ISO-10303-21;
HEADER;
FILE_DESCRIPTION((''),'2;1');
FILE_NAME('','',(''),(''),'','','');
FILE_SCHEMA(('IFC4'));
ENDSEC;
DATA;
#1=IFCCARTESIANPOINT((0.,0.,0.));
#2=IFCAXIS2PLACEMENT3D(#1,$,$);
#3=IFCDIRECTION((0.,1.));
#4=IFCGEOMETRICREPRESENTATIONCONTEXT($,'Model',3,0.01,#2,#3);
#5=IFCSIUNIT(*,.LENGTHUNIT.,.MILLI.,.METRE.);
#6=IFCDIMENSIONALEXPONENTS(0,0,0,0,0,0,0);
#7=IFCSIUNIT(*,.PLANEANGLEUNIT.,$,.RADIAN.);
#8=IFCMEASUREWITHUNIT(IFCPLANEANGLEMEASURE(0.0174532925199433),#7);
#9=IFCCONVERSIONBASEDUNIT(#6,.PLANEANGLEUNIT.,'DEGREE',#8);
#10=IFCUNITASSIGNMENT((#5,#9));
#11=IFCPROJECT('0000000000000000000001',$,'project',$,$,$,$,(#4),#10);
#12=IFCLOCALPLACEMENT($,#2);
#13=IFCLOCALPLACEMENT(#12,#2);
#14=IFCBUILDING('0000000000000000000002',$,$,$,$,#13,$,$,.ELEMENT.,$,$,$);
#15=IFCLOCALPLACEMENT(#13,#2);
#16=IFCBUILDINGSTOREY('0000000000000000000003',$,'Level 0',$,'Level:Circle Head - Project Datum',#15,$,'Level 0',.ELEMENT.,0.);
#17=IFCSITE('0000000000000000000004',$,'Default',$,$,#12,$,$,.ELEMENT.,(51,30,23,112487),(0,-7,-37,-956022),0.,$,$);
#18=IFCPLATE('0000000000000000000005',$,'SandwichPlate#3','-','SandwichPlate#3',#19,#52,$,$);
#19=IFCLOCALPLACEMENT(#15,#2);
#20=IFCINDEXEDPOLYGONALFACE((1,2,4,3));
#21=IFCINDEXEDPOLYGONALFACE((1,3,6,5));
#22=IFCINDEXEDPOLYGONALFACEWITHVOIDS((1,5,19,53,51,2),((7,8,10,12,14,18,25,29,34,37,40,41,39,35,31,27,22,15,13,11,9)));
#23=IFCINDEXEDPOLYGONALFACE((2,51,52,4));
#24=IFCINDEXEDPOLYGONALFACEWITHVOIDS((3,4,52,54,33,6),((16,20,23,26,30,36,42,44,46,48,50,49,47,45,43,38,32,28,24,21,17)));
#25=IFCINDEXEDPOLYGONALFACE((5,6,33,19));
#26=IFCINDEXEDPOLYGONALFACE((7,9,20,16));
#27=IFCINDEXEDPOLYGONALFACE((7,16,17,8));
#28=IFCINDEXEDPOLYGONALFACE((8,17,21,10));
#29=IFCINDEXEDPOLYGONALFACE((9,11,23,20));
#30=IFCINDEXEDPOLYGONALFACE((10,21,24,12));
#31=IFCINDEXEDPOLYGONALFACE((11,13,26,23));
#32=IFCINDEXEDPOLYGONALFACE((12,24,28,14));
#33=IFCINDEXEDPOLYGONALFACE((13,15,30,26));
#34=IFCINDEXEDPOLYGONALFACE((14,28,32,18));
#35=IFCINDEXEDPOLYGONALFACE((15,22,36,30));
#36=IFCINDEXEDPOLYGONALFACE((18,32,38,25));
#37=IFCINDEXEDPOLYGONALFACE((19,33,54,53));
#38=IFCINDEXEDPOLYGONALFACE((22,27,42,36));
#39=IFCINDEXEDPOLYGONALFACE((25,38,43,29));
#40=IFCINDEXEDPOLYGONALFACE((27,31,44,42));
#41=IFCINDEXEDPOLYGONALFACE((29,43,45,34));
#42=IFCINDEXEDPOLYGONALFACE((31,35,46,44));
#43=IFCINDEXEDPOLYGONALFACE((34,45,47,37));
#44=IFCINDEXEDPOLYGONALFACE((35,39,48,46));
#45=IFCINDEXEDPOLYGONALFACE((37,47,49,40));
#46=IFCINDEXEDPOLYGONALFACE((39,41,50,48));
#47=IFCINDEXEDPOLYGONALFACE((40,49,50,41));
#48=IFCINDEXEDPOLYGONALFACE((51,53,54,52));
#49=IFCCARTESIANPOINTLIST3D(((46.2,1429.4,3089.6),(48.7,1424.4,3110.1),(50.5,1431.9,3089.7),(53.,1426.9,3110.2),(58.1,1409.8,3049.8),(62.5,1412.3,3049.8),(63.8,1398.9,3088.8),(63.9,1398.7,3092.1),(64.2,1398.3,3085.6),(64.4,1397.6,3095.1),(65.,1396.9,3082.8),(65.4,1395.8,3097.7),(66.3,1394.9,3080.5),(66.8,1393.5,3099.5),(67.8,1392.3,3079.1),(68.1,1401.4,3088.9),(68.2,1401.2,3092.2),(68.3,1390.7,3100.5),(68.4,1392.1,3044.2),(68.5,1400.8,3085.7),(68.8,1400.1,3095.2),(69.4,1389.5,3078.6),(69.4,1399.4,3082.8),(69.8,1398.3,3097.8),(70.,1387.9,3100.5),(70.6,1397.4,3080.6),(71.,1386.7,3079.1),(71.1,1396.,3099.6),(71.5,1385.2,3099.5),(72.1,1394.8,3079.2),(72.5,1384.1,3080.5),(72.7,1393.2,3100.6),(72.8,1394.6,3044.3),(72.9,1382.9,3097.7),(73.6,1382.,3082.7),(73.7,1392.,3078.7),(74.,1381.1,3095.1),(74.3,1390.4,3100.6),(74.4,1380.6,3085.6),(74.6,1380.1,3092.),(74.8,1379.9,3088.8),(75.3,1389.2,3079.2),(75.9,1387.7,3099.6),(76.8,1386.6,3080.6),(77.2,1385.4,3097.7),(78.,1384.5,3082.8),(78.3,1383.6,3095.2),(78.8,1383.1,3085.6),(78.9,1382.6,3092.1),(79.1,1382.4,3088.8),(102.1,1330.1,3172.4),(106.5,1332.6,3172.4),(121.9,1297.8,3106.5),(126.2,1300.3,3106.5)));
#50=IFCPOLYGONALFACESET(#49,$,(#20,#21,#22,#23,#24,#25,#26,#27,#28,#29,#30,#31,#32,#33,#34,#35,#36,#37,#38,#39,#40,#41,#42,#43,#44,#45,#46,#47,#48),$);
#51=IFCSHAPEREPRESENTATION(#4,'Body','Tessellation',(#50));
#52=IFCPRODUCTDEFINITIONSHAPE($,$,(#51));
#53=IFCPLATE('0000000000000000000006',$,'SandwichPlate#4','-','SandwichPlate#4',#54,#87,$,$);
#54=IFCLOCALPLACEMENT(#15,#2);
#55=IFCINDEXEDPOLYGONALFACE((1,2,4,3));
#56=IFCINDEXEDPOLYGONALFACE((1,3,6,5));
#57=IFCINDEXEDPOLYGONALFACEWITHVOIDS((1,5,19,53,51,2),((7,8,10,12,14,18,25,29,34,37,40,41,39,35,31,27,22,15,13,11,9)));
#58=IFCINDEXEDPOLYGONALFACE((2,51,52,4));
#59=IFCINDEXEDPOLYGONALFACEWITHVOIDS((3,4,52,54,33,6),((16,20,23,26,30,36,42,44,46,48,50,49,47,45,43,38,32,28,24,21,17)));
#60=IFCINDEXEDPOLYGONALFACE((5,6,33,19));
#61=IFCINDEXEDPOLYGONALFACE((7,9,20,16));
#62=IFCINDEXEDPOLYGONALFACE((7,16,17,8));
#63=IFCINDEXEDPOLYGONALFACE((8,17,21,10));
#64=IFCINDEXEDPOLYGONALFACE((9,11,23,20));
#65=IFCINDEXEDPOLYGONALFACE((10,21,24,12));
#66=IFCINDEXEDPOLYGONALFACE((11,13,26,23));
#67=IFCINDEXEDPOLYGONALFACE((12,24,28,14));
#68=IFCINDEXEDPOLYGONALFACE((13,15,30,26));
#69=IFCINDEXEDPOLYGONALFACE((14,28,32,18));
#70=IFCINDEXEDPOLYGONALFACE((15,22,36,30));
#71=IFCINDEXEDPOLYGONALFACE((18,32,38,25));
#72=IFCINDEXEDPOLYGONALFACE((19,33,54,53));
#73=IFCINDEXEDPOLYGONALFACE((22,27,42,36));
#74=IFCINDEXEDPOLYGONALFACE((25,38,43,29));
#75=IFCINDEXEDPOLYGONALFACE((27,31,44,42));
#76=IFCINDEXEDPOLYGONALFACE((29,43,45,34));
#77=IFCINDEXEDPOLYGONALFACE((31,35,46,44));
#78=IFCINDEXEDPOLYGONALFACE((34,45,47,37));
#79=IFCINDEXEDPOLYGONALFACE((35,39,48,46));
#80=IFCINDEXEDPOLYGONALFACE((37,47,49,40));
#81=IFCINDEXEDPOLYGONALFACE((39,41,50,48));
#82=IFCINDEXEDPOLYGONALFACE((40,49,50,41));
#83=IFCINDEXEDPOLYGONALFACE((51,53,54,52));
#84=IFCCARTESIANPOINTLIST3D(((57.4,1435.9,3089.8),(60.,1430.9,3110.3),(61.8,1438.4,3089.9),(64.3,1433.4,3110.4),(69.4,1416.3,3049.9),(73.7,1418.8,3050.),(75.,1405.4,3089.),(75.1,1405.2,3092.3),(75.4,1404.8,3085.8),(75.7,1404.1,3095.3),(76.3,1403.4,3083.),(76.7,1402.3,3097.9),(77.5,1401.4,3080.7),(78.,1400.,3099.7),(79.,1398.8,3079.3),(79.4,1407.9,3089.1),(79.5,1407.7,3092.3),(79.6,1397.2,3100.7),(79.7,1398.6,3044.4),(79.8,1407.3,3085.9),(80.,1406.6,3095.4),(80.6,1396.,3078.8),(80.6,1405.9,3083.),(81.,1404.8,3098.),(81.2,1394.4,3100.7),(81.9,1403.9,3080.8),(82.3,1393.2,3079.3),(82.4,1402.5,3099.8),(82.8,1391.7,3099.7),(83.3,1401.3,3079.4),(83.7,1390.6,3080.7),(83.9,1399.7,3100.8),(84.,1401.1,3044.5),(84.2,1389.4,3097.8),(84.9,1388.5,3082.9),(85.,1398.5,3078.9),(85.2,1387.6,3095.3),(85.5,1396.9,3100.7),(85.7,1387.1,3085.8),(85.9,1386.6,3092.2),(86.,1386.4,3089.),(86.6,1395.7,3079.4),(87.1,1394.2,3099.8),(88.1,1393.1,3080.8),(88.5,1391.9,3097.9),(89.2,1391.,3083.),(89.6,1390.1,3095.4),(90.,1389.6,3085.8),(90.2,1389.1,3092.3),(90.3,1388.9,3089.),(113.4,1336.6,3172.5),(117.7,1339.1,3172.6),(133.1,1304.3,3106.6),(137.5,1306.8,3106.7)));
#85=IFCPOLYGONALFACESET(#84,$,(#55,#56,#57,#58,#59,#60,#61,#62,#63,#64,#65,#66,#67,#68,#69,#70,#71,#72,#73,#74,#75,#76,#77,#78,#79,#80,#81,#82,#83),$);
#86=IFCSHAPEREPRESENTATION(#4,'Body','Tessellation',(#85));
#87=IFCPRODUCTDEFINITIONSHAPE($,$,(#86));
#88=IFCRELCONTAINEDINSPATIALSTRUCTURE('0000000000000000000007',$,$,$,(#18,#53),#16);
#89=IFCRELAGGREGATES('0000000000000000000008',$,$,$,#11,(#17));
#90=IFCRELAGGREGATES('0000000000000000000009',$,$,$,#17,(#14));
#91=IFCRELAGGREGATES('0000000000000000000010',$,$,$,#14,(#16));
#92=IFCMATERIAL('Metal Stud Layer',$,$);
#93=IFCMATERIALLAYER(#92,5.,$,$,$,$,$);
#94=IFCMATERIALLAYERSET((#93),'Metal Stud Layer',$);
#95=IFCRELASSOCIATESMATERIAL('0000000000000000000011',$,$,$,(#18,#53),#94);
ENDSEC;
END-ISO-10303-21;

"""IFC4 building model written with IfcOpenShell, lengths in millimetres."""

from ifc_helpers import new_model, entity, si_unit, converted_unit, direction, frame, origin, origin_with_axes, origin_2d_with_axis, place, context, project, spatial, polyline, circle, outline, extrude, material, layer, layer_set, element, save


model = new_model("IFC4")

# Units and contexts
model_context = context("Model", 3, precision=0.01, world=origin(), true_north=direction((0.0, 1.0)))
ifc_project = project(units=[si_unit("LENGTHUNIT", "METRE", prefix="MILLI"), converted_unit("PLANEANGLEUNIT", "DEGREE", entity("IfcPlaneAngleMeasure", 0.0174532925199433), si_unit("PLANEANGLEUNIT", "RADIAN"), dimensions=[0, 0, 0, 0, 0, 0, 0])], contexts=[model_context])

# Site, building, storey
site_placement = place(None, origin())
site = spatial("IfcSite", under=ifc_project, at=site_placement, Name="Default", CompositionType="ELEMENT", RefLatitude=(51, 30, 23, 112487), RefLongitude=(0, -7, -37, -956022), RefElevation=0.0)
building_placement = place(site_placement, origin())
building = spatial("IfcBuilding", under=site, at=building_placement, CompositionType="ELEMENT")
storey_placement = place(building_placement, origin())
storey = spatial("IfcBuildingStorey", under=building, at=storey_placement, Name="Level 0", ObjectType="Level:Circle Head - Project Datum", LongName="Level 0", CompositionType="ELEMENT", Elevation=0.0)

# Plates, openings
ifc_material = material(Name="Metal Stud Layer")
ifc_layer_1 = layer(ifc_material, 5.0)
ifc_layer_set_1 = layer_set([ifc_layer_1], Name="Metal Stud Layer")
plate_1_placement = place(storey_placement, frame((62.0, 1403.5, 3036.7), z_axis=(0.865935, 0.499948, 0.014432), x_axis=(-0.259821, 0.424992, 0.867107)))
plate_1 = element("IfcPlate", 1, at=plate_1_placement, inside=storey, material=ifc_layer_set_1, Name="SandwichPlate#3", Description="-", ObjectType="SandwichPlate#3", context=model_context, shape_type="SweptSolid", body=[
    extrude(outline(polyline([(0.0, 0.0), (76.0, 0.0), (76.0, 140.0), (0.0, 140.0), (0.0, 0.0)])), origin_with_axes(), (0.0, 0.0, 1.0), 5.0),
])
opening_1_placement = place(plate_1_placement, frame((0.0, 0.0, 0.0), z_axis=(0.0, 0.0, 1.0), x_axis=(1.0, 0.0, 0.0)))
element("IfcOpeningElement", 2, at=opening_1_placement, cuts=plate_1, ObjectType="Opening", context=model_context, shape_type="SweptSolid", body=[
    extrude(outline(polyline([(0.0, 0.0), (15.0, 0.0), (0.0, 15.0), (0.0, 0.0)])), origin(), (0.0, 0.0, 1.0), 5.0),
])
opening_2_placement = place(plate_1_placement, frame((0.0, 0.0, 0.0), z_axis=(0.0, 0.0, 1.0), x_axis=(1.0, 0.0, 0.0)))
element("IfcOpeningElement", 3, at=opening_2_placement, cuts=plate_1, ObjectType="Opening", context=model_context, shape_type="SweptSolid", body=[
    extrude(outline(polyline([(76.0, 0.0), (76.0, 15.0), (61.0, 0.0), (76.0, 0.0)])), origin(), (0.0, 0.0, 1.0), 5.0),
])
opening_3_placement = place(plate_1_placement, frame((38.0, 40.0, -0.5), z_axis=(0.0, 0.0, 1.0), x_axis=(0.0, 1.0, 0.0)))
element("IfcOpeningElement", 4, at=opening_3_placement, cuts=plate_1, ObjectType="Opening", context=model_context, shape_type="SweptSolid", body=[
    extrude(circle(Radius=11.0, at=origin_2d_with_axis()), origin(), (0.0, 0.0, 1.0), 6.0),
])
plate_2_placement = place(storey_placement, frame((73.3, 1410.0, 3036.9), z_axis=(0.865935, 0.499948, 0.014432), x_axis=(-0.259821, 0.424992, 0.867107)))
plate_2 = element("IfcPlate", 5, at=plate_2_placement, inside=storey, material=ifc_layer_set_1, Name="SandwichPlate#4", Description="-", ObjectType="SandwichPlate#4", context=model_context, shape_type="SweptSolid", body=[
    extrude(outline(polyline([(0.0, 0.0), (76.0, 0.0), (76.0, 140.0), (0.0, 140.0), (0.0, 0.0)])), origin_with_axes(), (0.0, 0.0, 1.0), 5.0),
])
opening_4_placement = place(plate_2_placement, frame((0.0, 0.0, 0.0), z_axis=(0.0, 0.0, 1.0), x_axis=(1.0, 0.0, 0.0)))
element("IfcOpeningElement", 6, at=opening_4_placement, cuts=plate_2, ObjectType="Opening", context=model_context, shape_type="SweptSolid", body=[
    extrude(outline(polyline([(0.0, 0.0), (15.0, 0.0), (0.0, 15.0), (0.0, 0.0)])), origin(), (0.0, 0.0, 1.0), 5.0),
])
opening_5_placement = place(plate_2_placement, frame((0.0, 0.0, 0.0), z_axis=(0.0, 0.0, 1.0), x_axis=(1.0, 0.0, 0.0)))
element("IfcOpeningElement", 7, at=opening_5_placement, cuts=plate_2, ObjectType="Opening", context=model_context, shape_type="SweptSolid", body=[
    extrude(outline(polyline([(76.0, 0.0), (76.0, 15.0), (61.0, 0.0), (76.0, 0.0)])), origin(), (0.0, 0.0, 1.0), 5.0),
])
opening_6_placement = place(plate_2_placement, frame((38.0, 40.0, -0.5), z_axis=(0.0, 0.0, 1.0), x_axis=(0.0, 1.0, 0.0)))
element("IfcOpeningElement", 8, at=opening_6_placement, cuts=plate_2, ObjectType="Opening", context=model_context, shape_type="SweptSolid", body=[
    extrude(circle(Radius=11.0, at=origin_2d_with_axis()), origin(), (0.0, 0.0, 1.0), 6.0),
])

save(model, "model.ifc")
